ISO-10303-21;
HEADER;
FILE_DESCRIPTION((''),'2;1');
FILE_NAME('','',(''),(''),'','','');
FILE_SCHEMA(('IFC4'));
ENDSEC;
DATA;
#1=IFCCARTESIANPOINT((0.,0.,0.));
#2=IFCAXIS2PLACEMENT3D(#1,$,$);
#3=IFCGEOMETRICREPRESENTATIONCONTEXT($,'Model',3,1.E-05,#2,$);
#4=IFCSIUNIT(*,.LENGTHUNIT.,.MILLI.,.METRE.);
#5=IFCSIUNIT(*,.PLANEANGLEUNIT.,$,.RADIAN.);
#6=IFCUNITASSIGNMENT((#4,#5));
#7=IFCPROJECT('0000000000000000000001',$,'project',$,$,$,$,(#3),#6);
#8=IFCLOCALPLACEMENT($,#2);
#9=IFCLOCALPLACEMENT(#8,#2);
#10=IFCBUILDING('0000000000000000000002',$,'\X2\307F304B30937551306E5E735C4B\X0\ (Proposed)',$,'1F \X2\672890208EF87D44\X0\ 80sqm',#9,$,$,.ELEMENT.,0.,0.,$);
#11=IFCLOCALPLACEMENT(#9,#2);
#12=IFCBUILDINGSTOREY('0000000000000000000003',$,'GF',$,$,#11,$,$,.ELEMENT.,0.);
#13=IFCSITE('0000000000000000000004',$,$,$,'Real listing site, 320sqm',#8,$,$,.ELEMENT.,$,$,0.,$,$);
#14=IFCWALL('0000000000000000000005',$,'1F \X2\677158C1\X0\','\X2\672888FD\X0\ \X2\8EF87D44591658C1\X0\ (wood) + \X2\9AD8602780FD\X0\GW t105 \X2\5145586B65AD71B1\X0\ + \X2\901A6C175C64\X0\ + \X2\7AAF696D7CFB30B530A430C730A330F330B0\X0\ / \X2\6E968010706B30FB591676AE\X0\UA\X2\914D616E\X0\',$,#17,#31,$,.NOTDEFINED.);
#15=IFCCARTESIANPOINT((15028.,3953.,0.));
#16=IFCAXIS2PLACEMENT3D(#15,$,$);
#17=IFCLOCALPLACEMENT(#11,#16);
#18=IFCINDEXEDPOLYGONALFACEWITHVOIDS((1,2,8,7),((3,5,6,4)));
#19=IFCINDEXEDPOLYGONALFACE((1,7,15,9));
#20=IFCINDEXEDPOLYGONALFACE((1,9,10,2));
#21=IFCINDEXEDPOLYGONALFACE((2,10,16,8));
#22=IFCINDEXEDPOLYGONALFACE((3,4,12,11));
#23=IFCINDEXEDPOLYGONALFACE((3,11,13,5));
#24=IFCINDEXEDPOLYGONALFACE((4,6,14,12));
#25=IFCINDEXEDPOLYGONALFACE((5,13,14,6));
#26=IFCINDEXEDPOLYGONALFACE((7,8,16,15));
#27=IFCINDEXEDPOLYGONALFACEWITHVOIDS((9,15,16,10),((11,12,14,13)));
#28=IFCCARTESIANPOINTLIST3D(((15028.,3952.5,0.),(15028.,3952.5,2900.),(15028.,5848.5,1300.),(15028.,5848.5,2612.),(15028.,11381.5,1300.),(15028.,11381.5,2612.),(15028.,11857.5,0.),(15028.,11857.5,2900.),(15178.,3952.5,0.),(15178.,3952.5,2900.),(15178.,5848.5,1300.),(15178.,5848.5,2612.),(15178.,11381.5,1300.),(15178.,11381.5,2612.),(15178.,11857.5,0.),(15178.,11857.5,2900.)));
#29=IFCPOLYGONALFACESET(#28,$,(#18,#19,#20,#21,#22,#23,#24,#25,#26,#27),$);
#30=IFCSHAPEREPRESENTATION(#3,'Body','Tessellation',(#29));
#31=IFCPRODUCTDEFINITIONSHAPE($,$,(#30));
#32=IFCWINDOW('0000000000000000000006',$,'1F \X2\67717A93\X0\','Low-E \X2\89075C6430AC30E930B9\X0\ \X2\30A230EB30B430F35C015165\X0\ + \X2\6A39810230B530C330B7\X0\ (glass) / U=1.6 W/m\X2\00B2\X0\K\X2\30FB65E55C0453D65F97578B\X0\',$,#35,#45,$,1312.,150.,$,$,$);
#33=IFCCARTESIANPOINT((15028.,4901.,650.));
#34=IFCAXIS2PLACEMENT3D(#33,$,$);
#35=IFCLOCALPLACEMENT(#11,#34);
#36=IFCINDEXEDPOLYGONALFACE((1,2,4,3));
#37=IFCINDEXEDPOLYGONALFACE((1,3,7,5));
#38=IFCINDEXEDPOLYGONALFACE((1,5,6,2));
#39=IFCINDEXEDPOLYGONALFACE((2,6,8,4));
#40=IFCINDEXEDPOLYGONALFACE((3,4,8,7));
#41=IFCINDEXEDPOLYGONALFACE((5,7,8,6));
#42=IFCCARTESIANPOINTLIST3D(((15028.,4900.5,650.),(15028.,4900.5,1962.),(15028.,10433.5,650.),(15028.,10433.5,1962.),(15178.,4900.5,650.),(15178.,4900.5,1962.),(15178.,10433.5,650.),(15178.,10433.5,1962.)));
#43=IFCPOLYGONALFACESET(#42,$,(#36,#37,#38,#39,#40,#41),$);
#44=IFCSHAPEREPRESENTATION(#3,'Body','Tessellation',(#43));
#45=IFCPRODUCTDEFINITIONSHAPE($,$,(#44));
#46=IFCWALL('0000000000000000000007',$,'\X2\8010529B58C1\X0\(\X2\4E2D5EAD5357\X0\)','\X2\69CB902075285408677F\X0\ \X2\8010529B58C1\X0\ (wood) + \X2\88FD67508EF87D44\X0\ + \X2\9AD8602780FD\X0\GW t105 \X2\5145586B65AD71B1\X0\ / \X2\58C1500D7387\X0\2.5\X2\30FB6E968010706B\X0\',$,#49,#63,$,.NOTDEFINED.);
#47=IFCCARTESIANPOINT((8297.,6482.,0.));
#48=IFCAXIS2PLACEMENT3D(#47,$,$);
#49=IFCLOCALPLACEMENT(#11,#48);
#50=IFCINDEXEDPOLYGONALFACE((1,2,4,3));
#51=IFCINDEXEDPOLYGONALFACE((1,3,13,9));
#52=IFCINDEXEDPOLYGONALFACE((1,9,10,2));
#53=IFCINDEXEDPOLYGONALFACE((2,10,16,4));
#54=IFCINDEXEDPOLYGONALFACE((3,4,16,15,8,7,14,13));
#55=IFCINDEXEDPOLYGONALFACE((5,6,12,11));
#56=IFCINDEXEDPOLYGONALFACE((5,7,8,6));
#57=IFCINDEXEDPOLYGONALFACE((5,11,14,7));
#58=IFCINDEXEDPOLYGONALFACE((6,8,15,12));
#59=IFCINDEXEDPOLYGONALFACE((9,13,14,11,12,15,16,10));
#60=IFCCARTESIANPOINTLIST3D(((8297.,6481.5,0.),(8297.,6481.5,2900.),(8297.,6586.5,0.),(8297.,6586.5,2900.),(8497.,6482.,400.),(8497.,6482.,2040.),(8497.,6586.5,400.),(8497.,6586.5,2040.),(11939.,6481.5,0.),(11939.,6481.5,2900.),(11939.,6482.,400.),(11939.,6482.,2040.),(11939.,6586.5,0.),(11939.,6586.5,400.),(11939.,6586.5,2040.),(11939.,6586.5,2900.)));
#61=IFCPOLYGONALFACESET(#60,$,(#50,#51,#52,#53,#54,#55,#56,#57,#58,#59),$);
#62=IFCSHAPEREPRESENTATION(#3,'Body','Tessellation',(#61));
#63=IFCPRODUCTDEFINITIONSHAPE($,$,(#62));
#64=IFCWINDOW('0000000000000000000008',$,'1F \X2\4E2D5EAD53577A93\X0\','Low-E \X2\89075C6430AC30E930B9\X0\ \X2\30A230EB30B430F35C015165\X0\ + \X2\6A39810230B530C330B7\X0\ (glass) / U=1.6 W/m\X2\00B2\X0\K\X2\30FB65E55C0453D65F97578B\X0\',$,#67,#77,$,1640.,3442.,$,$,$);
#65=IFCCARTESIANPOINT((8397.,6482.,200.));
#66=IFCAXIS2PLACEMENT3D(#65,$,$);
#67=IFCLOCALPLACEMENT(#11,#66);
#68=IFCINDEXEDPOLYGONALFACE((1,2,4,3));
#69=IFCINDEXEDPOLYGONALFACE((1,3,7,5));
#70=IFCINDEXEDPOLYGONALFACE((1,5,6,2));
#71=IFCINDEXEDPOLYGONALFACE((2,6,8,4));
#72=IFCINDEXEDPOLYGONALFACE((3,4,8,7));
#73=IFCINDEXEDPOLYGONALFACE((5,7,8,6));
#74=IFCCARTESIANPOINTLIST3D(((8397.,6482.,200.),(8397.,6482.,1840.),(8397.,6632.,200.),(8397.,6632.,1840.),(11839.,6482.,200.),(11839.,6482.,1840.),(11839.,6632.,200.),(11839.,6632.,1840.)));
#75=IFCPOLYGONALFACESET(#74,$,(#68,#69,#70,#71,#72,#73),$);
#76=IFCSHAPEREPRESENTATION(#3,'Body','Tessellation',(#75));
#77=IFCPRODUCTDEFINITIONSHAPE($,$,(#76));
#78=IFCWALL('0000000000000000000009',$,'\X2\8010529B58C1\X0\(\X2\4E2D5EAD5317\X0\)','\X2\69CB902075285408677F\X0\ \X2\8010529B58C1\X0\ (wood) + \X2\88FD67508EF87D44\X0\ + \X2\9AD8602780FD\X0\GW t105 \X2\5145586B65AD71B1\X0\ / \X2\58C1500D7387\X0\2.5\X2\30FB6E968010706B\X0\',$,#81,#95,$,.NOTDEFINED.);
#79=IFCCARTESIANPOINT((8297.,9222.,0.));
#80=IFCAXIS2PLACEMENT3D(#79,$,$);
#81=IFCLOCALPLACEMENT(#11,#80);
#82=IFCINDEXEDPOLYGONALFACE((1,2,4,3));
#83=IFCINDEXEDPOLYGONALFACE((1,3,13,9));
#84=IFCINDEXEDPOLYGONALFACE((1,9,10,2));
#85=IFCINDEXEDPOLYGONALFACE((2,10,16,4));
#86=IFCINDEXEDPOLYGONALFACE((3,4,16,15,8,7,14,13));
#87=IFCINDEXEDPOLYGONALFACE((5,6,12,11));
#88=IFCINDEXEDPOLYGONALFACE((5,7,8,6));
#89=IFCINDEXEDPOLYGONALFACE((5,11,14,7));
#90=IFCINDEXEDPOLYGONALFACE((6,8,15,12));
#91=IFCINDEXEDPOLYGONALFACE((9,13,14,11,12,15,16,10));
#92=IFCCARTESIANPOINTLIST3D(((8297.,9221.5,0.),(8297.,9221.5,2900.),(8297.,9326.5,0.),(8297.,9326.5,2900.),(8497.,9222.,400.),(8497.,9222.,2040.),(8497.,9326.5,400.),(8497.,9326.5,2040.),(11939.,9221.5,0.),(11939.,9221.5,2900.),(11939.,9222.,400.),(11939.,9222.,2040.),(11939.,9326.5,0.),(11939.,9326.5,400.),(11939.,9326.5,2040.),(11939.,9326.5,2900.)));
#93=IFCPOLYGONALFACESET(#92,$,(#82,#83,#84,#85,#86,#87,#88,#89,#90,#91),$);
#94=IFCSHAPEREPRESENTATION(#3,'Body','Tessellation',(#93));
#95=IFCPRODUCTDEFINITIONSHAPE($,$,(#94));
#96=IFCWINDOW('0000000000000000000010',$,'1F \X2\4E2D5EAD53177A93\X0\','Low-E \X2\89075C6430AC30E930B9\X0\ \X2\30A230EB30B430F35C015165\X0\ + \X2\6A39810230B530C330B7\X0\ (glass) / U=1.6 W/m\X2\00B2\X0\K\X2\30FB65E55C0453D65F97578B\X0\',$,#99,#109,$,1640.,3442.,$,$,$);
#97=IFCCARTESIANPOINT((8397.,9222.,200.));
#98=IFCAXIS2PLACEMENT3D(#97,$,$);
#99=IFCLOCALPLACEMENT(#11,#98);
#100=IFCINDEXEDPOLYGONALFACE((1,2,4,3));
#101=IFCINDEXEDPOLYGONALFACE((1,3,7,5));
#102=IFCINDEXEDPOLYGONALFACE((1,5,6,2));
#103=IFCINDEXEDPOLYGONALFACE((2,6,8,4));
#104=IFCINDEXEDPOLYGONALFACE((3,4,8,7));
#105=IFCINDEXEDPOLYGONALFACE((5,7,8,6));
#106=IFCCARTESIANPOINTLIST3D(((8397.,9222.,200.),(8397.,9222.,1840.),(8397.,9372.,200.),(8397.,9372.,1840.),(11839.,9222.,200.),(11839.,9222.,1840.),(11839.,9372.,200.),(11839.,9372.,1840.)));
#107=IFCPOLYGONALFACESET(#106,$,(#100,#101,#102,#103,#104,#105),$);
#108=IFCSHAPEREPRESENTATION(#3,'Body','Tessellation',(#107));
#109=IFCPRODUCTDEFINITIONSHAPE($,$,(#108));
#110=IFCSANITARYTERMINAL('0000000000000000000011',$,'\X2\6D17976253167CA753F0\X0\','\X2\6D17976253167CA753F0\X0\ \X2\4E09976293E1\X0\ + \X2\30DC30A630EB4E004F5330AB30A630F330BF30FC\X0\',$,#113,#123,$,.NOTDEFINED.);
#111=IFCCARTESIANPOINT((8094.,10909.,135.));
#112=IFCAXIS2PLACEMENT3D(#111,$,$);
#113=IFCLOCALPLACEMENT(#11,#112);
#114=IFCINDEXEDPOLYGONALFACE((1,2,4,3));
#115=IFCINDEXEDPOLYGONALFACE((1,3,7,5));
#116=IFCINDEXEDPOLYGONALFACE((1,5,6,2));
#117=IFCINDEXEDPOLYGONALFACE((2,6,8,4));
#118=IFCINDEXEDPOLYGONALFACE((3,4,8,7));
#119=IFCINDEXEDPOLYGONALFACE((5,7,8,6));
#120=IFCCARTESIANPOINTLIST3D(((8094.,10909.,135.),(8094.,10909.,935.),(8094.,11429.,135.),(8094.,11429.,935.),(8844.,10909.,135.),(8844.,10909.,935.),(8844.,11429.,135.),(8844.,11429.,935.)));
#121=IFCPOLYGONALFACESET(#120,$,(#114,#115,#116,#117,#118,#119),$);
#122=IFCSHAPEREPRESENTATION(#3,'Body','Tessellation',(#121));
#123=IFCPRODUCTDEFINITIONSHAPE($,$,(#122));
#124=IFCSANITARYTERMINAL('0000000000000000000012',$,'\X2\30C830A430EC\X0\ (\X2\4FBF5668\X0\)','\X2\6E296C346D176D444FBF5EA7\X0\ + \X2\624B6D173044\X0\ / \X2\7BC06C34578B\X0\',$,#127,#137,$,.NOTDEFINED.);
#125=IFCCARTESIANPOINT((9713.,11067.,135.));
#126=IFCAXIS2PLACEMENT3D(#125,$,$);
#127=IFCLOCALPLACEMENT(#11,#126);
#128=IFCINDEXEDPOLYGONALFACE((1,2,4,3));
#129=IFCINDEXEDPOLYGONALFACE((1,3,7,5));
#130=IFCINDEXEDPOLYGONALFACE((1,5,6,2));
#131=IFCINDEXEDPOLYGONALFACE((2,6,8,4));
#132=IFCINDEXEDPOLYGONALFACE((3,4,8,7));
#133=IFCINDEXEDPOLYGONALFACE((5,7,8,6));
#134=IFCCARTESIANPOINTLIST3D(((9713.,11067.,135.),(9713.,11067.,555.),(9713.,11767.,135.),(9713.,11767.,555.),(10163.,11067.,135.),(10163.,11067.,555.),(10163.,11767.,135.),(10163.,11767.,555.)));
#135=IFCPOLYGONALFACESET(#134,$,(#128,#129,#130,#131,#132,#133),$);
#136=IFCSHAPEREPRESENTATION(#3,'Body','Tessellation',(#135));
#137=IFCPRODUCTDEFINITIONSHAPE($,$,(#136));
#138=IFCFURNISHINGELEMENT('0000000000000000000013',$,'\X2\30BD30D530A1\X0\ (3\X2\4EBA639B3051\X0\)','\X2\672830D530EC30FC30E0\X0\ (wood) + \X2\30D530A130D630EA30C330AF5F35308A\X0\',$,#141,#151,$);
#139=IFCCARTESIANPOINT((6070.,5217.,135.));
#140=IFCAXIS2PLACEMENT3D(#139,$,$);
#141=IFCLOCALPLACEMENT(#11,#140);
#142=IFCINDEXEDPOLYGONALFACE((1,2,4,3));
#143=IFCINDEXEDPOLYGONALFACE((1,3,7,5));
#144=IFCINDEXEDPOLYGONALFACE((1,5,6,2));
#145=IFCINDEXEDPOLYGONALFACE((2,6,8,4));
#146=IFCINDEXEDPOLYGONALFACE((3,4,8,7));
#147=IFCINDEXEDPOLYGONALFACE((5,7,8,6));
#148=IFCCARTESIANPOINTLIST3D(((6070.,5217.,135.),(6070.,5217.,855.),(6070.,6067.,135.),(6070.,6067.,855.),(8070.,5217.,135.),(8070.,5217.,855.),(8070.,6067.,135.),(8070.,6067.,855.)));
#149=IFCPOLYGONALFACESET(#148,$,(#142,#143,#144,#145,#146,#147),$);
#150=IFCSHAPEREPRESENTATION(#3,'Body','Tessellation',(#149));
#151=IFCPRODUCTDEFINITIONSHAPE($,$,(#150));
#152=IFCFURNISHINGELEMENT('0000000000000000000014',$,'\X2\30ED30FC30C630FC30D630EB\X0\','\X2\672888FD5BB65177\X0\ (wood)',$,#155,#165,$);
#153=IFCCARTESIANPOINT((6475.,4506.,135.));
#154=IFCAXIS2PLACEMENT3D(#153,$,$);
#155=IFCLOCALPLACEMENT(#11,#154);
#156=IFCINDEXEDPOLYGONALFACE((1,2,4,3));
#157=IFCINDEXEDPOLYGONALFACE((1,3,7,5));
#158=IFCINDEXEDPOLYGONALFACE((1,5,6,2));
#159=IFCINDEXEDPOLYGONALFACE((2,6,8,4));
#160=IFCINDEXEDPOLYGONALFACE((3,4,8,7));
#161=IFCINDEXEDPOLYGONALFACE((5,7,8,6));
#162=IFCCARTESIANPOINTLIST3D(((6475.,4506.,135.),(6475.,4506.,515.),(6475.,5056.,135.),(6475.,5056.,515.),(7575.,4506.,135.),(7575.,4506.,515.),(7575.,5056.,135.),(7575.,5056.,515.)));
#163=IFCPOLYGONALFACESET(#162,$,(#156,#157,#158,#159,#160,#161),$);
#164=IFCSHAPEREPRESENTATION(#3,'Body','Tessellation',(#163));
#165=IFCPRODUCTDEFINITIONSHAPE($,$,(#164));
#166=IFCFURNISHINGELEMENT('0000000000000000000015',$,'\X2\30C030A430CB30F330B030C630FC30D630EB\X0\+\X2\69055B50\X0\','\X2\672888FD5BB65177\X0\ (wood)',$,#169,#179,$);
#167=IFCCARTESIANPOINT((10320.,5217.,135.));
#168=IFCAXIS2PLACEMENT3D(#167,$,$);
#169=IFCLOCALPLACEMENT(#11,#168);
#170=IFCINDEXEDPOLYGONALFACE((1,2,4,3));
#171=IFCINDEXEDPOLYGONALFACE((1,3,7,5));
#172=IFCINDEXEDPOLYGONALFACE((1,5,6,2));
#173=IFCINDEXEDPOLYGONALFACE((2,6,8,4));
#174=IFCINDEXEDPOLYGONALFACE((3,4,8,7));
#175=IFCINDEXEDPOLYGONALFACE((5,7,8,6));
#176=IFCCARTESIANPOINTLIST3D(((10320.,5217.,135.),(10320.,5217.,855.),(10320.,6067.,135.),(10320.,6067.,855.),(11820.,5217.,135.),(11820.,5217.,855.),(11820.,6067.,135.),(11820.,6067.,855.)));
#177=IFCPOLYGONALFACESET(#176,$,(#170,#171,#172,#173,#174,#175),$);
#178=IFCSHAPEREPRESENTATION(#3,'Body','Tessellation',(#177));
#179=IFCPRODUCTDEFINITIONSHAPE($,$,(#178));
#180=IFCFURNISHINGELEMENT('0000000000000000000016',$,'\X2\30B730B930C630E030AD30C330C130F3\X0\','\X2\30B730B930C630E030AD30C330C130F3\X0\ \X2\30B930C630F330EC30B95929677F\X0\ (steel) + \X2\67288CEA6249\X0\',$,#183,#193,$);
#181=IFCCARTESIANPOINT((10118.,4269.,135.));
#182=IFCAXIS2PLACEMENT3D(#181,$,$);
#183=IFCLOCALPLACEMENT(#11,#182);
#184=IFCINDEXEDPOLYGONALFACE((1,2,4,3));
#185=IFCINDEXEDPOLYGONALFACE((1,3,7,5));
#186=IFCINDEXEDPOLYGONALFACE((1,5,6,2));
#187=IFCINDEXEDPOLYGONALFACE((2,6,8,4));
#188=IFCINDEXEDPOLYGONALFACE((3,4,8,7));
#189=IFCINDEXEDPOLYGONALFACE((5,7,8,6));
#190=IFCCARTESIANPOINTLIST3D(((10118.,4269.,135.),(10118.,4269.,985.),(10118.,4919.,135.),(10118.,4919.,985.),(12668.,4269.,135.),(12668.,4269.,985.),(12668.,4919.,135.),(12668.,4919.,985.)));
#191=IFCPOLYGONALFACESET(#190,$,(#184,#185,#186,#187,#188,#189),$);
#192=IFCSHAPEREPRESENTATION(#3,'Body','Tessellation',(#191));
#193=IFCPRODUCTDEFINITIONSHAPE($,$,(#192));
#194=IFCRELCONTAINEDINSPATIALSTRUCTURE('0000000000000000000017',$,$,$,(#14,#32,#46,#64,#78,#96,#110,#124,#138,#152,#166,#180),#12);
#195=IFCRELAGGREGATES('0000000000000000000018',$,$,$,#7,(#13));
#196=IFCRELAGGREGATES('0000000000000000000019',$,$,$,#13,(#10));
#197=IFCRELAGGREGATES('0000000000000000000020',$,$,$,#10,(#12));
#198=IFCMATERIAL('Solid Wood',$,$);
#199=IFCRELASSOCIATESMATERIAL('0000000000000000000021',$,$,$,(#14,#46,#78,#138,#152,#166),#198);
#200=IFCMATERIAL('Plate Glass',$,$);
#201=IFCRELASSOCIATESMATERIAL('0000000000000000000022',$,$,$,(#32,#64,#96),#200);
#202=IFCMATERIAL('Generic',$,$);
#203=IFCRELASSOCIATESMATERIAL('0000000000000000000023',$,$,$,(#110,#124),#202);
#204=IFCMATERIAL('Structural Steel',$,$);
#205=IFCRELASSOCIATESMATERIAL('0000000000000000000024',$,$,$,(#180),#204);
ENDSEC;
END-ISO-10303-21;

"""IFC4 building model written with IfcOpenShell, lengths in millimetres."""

from ifc_helpers import new_model, si_unit, frame, frame_2d, origin, place, context, project, spatial, rectangle, extrude, material, element, fill, save


model = new_model("IFC4")

# Units and contexts
model_context = context("Model", 3, precision=1e-05, world=origin())
ifc_project = project(units=[si_unit("LENGTHUNIT", "METRE", prefix="MILLI"), si_unit("PLANEANGLEUNIT", "RADIAN")], contexts=[model_context])

# Site, building, storey
site_placement = place(None, origin())
site = spatial("IfcSite", under=ifc_project, at=site_placement, ObjectType="Real listing site, 320sqm", CompositionType="ELEMENT", RefElevation=0.0)
building_placement = place(site_placement, origin())
building = spatial("IfcBuilding", under=site, at=building_placement, Name="みかん畑の平屋 (Proposed)", ObjectType="1F 木造軸組 80sqm", CompositionType="ELEMENT", ElevationOfRefHeight=0.0, ElevationOfTerrain=0.0)
storey_placement = place(building_placement, origin())
storey = spatial("IfcBuildingStorey", under=building, at=storey_placement, Name="GF", CompositionType="ELEMENT", Elevation=0.0)

# Shared definitions
ifc_material_1 = material(Name="Solid Wood")

# Walls, openings, windows
wall_1_placement = place(storey_placement, frame((15028.0, 3953.0, 0.0)))
wall_1 = element("IfcWall", 1, at=wall_1_placement, inside=storey, material=ifc_material_1, Name="1F 東壁", Description="木製 軸組外壁 (wood) + 高性能GW t105 充填断熱 + 通気層 + 窯業系サイディング / 準耐火・外皮UA配慮", PredefinedType="NOTDEFINED", context=model_context, shape_type="SweptSolid", body=[
    extrude(rectangle(XDim=150.0, YDim=7905.0, at=frame_2d((75.0, 3952.0))), frame((15028.0, 3953.0, 0.0)), (0.0, 0.0, 1.0), 2900.0),
])
opening_1_placement = place(storey_placement, frame((15028.0, 4901.0, 650.0)))
opening_1 = element("IfcOpeningElement", 2, at=opening_1_placement, cuts=wall_1, PredefinedType="NOTDEFINED", context=model_context, shape_type="SweptSolid", body=[
    extrude(rectangle(XDim=150.0, YDim=5533.0, at=frame_2d((75.0, 2766.0))), frame((15028.0, 4901.0, 650.0)), (0.0, 0.0, 1.0), 1312.0),
])
ifc_material_2 = material(Name="Plate Glass")
window_1_placement = place(storey_placement, frame((15028.0, 4901.0, 650.0)))
window_1 = element("IfcWindow", 3, at=window_1_placement, inside=storey, material=ifc_material_2, Name="1F 東窓", Description="Low-E 複層ガラス アルゴン封入 + 樹脂サッシ (glass) / U=1.6 W/m²K・日射取得型", OverallHeight=1312.0, OverallWidth=150.0, context=model_context, shape_type="SweptSolid", body=[
    extrude(rectangle(XDim=150.0, YDim=5533.0, at=frame_2d((75.0, 2766.0))), frame((15028.0, 4901.0, 650.0)), (0.0, 0.0, 1.0), 1312.0),
])
fill(opening_1, window_1)
wall_2_placement = place(storey_placement, frame((8297.0, 6482.0, 0.0)))
wall_2 = element("IfcWall", 4, at=wall_2_placement, inside=storey, material=ifc_material_1, Name="耐力壁(中庭南)", Description="構造用合板 耐力壁 (wood) + 製材軸組 + 高性能GW t105 充填断熱 / 壁倍率2.5・準耐火", PredefinedType="NOTDEFINED", context=model_context, shape_type="SweptSolid", body=[
    extrude(rectangle(XDim=3642.0, YDim=105.0, at=frame_2d((1821.0, 52.0))), frame((8297.0, 6482.0, 0.0)), (0.0, 0.0, 1.0), 2900.0),
])
opening_2_placement = place(storey_placement, frame((8397.0, 6482.0, 200.0)))
opening_2 = element("IfcOpeningElement", 5, at=opening_2_placement, cuts=wall_2, PredefinedType="NOTDEFINED", context=model_context, shape_type="SweptSolid", body=[
    extrude(rectangle(XDim=3442.0, YDim=150.0, at=frame_2d((1721.0, 75.0))), frame((8397.0, 6482.0, 200.0)), (0.0, 0.0, 1.0), 1640.0),
])
window_2_placement = place(storey_placement, frame((8397.0, 6482.0, 200.0)))
window_2 = element("IfcWindow", 6, at=window_2_placement, inside=storey, material=ifc_material_2, Name="1F 中庭南窓", Description="Low-E 複層ガラス アルゴン封入 + 樹脂サッシ (glass) / U=1.6 W/m²K・日射取得型", OverallHeight=1640.0, OverallWidth=3442.0, context=model_context, shape_type="SweptSolid", body=[
    extrude(rectangle(XDim=3442.0, YDim=150.0, at=frame_2d((1721.0, 75.0))), frame((8397.0, 6482.0, 200.0)), (0.0, 0.0, 1.0), 1640.0),
])
fill(opening_2, window_2)
wall_3_placement = place(storey_placement, frame((8297.0, 9222.0, 0.0)))
wall_3 = element("IfcWall", 7, at=wall_3_placement, inside=storey, material=ifc_material_1, Name="耐力壁(中庭北)", Description="構造用合板 耐力壁 (wood) + 製材軸組 + 高性能GW t105 充填断熱 / 壁倍率2.5・準耐火", PredefinedType="NOTDEFINED", context=model_context, shape_type="SweptSolid", body=[
    extrude(rectangle(XDim=3642.0, YDim=105.0, at=frame_2d((1821.0, 52.0))), frame((8297.0, 9222.0, 0.0)), (0.0, 0.0, 1.0), 2900.0),
])
opening_3_placement = place(storey_placement, frame((8397.0, 9222.0, 200.0)))
opening_3 = element("IfcOpeningElement", 8, at=opening_3_placement, cuts=wall_3, PredefinedType="NOTDEFINED", context=model_context, shape_type="SweptSolid", body=[
    extrude(rectangle(XDim=3442.0, YDim=150.0, at=frame_2d((1721.0, 75.0))), frame((8397.0, 9222.0, 200.0)), (0.0, 0.0, 1.0), 1640.0),
])
window_3_placement = place(storey_placement, frame((8397.0, 9222.0, 200.0)))
window_3 = element("IfcWindow", 9, at=window_3_placement, inside=storey, material=ifc_material_2, Name="1F 中庭北窓", Description="Low-E 複層ガラス アルゴン封入 + 樹脂サッシ (glass) / U=1.6 W/m²K・日射取得型", OverallHeight=1640.0, OverallWidth=3442.0, context=model_context, shape_type="SweptSolid", body=[
    extrude(rectangle(XDim=3442.0, YDim=150.0, at=frame_2d((1721.0, 75.0))), frame((8397.0, 9222.0, 200.0)), (0.0, 0.0, 1.0), 1640.0),
])
fill(opening_3, window_3)

# Shared definitions
ifc_material_3 = material(Name="Structural Steel")

# Shared definitions
ifc_material_4 = material(Name="Generic")

# Sanitary terminals
sanitary_terminal_1_placement = place(storey_placement, frame((8094.0, 10909.0, 135.0)))
element("IfcSanitaryTerminal", 10, at=sanitary_terminal_1_placement, inside=storey, material=ifc_material_4, Name="洗面化粧台", Description="洗面化粧台 三面鏡 + ボウル一体カウンター", PredefinedType="NOTDEFINED", context=model_context, shape_type="SweptSolid", body=[
    extrude(rectangle(XDim=750.0, YDim=520.0, at=frame_2d((375.0, 260.0))), frame((8094.0, 10909.0, 135.0)), (0.0, 0.0, 1.0), 800.0),
])
sanitary_terminal_2_placement = place(storey_placement, frame((9713.0, 11067.0, 135.0)))
element("IfcSanitaryTerminal", 11, at=sanitary_terminal_2_placement, inside=storey, material=ifc_material_4, Name="トイレ (便器)", Description="温水洗浄便座 + 手洗い / 節水型", PredefinedType="NOTDEFINED", context=model_context, shape_type="SweptSolid", body=[
    extrude(rectangle(XDim=450.0, YDim=700.0, at=frame_2d((225.0, 350.0))), frame((9713.0, 11067.0, 135.0)), (0.0, 0.0, 1.0), 420.0),
])

# Furnishing elements
furnishing_1_placement = place(storey_placement, frame((6070.0, 5217.0, 135.0)))
element("IfcFurnishingElement", 12, at=furnishing_1_placement, inside=storey, material=ifc_material_1, Name="ソファ (3人掛け)", Description="木フレーム (wood) + ファブリック張り", context=model_context, shape_type="SweptSolid", body=[
    extrude(rectangle(XDim=2000.0, YDim=850.0, at=frame_2d((1000.0, 425.0))), frame((6070.0, 5217.0, 135.0)), (0.0, 0.0, 1.0), 720.0),
])
furnishing_2_placement = place(storey_placement, frame((6475.0, 4506.0, 135.0)))
element("IfcFurnishingElement", 13, at=furnishing_2_placement, inside=storey, material=ifc_material_1, Name="ローテーブル", Description="木製家具 (wood)", context=model_context, shape_type="SweptSolid", body=[
    extrude(rectangle(XDim=1100.0, YDim=550.0, at=frame_2d((550.0, 275.0))), frame((6475.0, 4506.0, 135.0)), (0.0, 0.0, 1.0), 380.0),
])
furnishing_3_placement = place(storey_placement, frame((10320.0, 5217.0, 135.0)))
element("IfcFurnishingElement", 14, at=furnishing_3_placement, inside=storey, material=ifc_material_1, Name="ダイニングテーブル+椅子", Description="木製家具 (wood)", context=model_context, shape_type="SweptSolid", body=[
    extrude(rectangle(XDim=1500.0, YDim=850.0, at=frame_2d((750.0, 425.0))), frame((10320.0, 5217.0, 135.0)), (0.0, 0.0, 1.0), 720.0),
])
furnishing_4_placement = place(storey_placement, frame((10118.0, 4269.0, 135.0)))
element("IfcFurnishingElement", 15, at=furnishing_4_placement, inside=storey, material=ifc_material_3, Name="システムキッチン", Description="システムキッチン ステンレス天板 (steel) + 木質扉", context=model_context, shape_type="SweptSolid", body=[
    extrude(rectangle(XDim=2550.0, YDim=650.0, at=frame_2d((1275.0, 325.0))), frame((10118.0, 4269.0, 135.0)), (0.0, 0.0, 1.0), 850.0),
])

save(model, "model.ifc")
